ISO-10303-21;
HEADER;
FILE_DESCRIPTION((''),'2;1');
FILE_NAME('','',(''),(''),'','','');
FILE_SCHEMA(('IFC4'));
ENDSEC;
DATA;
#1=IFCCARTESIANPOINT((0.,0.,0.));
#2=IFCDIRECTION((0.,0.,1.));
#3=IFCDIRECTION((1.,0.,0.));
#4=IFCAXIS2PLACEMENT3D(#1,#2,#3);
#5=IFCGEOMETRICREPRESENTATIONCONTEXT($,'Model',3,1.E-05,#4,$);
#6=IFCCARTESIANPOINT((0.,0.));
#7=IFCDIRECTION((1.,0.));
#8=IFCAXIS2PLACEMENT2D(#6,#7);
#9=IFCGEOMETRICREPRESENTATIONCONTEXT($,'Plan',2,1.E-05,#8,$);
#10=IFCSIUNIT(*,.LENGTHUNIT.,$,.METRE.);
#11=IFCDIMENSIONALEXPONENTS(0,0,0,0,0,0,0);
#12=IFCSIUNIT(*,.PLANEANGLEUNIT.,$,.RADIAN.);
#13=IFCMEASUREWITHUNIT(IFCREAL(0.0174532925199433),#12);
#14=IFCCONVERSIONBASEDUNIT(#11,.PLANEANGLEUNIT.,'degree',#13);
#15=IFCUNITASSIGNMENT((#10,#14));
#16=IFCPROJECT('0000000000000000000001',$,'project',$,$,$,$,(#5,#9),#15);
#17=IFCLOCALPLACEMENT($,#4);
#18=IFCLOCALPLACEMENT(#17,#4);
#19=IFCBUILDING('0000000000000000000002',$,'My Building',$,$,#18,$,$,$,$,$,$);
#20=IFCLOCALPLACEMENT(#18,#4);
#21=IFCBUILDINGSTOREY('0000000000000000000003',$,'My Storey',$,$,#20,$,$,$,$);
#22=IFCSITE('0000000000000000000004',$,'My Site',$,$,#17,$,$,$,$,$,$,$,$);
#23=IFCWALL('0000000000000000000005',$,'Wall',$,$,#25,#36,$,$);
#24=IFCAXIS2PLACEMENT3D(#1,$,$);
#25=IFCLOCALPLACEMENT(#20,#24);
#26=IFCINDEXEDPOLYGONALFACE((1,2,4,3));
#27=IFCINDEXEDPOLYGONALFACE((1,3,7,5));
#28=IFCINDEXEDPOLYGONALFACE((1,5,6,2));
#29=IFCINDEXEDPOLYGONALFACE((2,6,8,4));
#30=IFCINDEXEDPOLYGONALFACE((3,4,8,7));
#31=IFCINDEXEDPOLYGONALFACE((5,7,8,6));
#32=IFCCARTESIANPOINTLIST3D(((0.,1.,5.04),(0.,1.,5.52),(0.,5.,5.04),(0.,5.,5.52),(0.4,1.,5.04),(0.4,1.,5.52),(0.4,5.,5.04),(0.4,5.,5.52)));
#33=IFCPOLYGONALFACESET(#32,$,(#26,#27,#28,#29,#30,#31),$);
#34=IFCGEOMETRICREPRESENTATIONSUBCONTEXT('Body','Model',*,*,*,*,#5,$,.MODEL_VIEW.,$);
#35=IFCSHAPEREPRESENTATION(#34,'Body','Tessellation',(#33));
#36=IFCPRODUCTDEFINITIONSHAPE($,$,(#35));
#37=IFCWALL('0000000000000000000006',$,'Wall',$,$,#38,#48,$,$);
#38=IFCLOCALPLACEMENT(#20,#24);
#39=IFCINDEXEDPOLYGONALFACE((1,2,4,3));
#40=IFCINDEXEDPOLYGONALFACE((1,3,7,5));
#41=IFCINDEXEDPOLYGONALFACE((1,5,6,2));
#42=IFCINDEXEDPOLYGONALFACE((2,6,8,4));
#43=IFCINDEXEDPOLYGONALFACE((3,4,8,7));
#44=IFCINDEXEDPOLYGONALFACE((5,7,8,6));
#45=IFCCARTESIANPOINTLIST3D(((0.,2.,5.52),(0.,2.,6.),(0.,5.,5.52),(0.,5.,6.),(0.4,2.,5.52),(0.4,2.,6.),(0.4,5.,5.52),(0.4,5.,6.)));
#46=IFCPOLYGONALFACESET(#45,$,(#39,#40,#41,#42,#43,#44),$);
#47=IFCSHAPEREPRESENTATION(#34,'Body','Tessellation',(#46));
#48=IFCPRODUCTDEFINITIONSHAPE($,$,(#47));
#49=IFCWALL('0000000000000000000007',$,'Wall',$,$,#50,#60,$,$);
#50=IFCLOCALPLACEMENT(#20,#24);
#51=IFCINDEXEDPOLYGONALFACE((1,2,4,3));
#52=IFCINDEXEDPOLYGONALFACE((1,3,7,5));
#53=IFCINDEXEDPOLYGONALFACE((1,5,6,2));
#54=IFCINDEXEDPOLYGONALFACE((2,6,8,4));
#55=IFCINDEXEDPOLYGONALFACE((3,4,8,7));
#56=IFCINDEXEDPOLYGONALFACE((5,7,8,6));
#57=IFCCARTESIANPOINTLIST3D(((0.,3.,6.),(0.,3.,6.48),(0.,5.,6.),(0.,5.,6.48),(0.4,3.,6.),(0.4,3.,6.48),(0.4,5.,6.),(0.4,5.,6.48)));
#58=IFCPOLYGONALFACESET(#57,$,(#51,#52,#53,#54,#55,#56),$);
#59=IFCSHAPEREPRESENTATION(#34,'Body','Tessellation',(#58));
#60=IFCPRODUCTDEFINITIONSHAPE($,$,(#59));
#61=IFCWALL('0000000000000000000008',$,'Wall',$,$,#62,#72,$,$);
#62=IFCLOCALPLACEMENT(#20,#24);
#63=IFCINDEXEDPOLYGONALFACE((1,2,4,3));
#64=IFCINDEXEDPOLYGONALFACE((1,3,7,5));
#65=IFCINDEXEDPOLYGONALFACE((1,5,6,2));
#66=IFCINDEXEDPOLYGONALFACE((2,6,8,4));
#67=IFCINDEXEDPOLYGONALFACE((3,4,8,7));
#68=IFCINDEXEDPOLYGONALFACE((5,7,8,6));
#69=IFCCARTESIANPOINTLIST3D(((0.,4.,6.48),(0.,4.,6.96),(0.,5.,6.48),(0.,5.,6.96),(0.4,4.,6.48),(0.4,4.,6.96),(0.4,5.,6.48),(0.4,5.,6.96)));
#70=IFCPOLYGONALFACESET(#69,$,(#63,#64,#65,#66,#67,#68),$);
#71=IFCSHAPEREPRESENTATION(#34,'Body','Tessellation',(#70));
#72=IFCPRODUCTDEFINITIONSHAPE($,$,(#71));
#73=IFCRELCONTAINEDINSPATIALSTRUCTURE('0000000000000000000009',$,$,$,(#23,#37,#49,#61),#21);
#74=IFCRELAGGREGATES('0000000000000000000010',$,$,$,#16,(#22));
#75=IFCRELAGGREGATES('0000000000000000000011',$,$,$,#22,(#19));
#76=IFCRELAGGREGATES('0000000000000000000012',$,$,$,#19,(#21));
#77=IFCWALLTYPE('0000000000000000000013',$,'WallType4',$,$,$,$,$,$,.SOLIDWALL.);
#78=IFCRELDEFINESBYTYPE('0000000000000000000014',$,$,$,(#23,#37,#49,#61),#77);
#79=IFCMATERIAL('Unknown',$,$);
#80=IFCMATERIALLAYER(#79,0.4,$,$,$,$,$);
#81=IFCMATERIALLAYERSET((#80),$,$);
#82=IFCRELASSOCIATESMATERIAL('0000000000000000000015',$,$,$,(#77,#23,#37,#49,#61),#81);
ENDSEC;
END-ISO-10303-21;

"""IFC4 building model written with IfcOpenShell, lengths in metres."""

from ifc_helpers import new_model, entity, si_unit, converted_unit, frame, origin_with_axes, origin_2d_with_axis, place, context, subcontext, project, spatial, indexed_curve, outline, extrude, material, layer, layer_set, layer_usage, type_object, element, save


model = new_model("IFC4")

# Units and contexts
model_context = context("Model", 3, precision=1e-05, world=origin_with_axes())
plan_context = context("Plan", 2, precision=1e-05, world=origin_2d_with_axis())
body_context_1 = subcontext(model_context, "Body", "Model", "MODEL_VIEW")
ifc_project = project(units=[si_unit("LENGTHUNIT", "METRE"), converted_unit("PLANEANGLEUNIT", "degree", entity("IfcReal", 0.0174532925199433), si_unit("PLANEANGLEUNIT", "RADIAN"), dimensions=[0, 0, 0, 0, 0, 0, 0])], contexts=[model_context, plan_context])

# Site, building, storey
site_placement = place(None, origin_with_axes())
site = spatial("IfcSite", under=ifc_project, at=site_placement, Name="My Site")
building_placement = place(site_placement, origin_with_axes())
building = spatial("IfcBuilding", under=site, at=building_placement, Name="My Building")
storey_placement = place(building_placement, origin_with_axes())
storey = spatial("IfcBuildingStorey", under=building, at=storey_placement, Name="My Storey")

# Shared definitions
ifc_material = material(Name="Unknown")

# Shared definitions
ifc_layer_1 = layer(ifc_material, 0.4)
ifc_layer_set_1 = layer_set([ifc_layer_1])
wall_type_1 = type_object("IfcWallType", Name="WallType4", PredefinedType="SOLIDWALL", material=ifc_layer_set_1)

# Walls
ifc_layer_usage_1 = layer_usage(ifc_layer_set_1, "AXIS2", "POSITIVE", 0.0)
wall_1_placement = place(storey_placement, frame((0.4, 1.0, 5.04), z_axis=(0.0, 0.0, 1.0), x_axis=(0.0, 1.0, 0.0)))
element("IfcWall", 1, at=wall_1_placement, inside=storey, type_object=wall_type_1, material=ifc_layer_usage_1, Name="Wall", context=body_context_1, shape_type="SweptSolid", body=[
    extrude(outline(indexed_curve([(0.0, 0.0), (0.0, 0.4), (4.0, 0.4), (4.0, 0.0), (0.0, 0.0)], self_intersect=False)), origin_with_axes(), (0.0, 0.0, 1.0), 0.48),
])
ifc_layer_usage_2 = layer_usage(ifc_layer_set_1, "AXIS2", "POSITIVE", 0.0)
wall_2_placement = place(storey_placement, frame((0.4, 2.0, 5.52), z_axis=(0.0, 0.0, 1.0), x_axis=(0.0, 1.0, 0.0)))
element("IfcWall", 2, at=wall_2_placement, inside=storey, type_object=wall_type_1, material=ifc_layer_usage_2, Name="Wall", context=body_context_1, shape_type="SweptSolid", body=[
    extrude(outline(indexed_curve([(0.0, 0.0), (0.0, 0.4), (3.0, 0.4), (3.0, 0.0), (0.0, 0.0)], self_intersect=False)), origin_with_axes(), (0.0, 0.0, 1.0), 0.48),
])
ifc_layer_usage_3 = layer_usage(ifc_layer_set_1, "AXIS2", "POSITIVE", 0.0)
wall_3_placement = place(storey_placement, frame((0.4, 3.0, 6.0), z_axis=(0.0, 0.0, 1.0), x_axis=(0.0, 1.0, 0.0)))
element("IfcWall", 3, at=wall_3_placement, inside=storey, type_object=wall_type_1, material=ifc_layer_usage_3, Name="Wall", context=body_context_1, shape_type="SweptSolid", body=[
    extrude(outline(indexed_curve([(0.0, 0.0), (0.0, 0.4), (2.0, 0.4), (2.0, 0.0), (0.0, 0.0)], self_intersect=False)), origin_with_axes(), (0.0, 0.0, 1.0), 0.48),
])
ifc_layer_usage_4 = layer_usage(ifc_layer_set_1, "AXIS2", "POSITIVE", 0.0)
wall_4_placement = place(storey_placement, frame((0.4, 4.0, 6.48), z_axis=(0.0, 0.0, 1.0), x_axis=(0.0, 1.0, 0.0)))
element("IfcWall", 4, at=wall_4_placement, inside=storey, type_object=wall_type_1, material=ifc_layer_usage_4, Name="Wall", context=body_context_1, shape_type="SweptSolid", body=[
    extrude(outline(indexed_curve([(0.0, 0.0), (0.0, 0.4), (1.0, 0.4), (1.0, 0.0), (0.0, 0.0)], self_intersect=False)), origin_with_axes(), (0.0, 0.0, 1.0), 0.48),
])

save(model, "model.ifc")
